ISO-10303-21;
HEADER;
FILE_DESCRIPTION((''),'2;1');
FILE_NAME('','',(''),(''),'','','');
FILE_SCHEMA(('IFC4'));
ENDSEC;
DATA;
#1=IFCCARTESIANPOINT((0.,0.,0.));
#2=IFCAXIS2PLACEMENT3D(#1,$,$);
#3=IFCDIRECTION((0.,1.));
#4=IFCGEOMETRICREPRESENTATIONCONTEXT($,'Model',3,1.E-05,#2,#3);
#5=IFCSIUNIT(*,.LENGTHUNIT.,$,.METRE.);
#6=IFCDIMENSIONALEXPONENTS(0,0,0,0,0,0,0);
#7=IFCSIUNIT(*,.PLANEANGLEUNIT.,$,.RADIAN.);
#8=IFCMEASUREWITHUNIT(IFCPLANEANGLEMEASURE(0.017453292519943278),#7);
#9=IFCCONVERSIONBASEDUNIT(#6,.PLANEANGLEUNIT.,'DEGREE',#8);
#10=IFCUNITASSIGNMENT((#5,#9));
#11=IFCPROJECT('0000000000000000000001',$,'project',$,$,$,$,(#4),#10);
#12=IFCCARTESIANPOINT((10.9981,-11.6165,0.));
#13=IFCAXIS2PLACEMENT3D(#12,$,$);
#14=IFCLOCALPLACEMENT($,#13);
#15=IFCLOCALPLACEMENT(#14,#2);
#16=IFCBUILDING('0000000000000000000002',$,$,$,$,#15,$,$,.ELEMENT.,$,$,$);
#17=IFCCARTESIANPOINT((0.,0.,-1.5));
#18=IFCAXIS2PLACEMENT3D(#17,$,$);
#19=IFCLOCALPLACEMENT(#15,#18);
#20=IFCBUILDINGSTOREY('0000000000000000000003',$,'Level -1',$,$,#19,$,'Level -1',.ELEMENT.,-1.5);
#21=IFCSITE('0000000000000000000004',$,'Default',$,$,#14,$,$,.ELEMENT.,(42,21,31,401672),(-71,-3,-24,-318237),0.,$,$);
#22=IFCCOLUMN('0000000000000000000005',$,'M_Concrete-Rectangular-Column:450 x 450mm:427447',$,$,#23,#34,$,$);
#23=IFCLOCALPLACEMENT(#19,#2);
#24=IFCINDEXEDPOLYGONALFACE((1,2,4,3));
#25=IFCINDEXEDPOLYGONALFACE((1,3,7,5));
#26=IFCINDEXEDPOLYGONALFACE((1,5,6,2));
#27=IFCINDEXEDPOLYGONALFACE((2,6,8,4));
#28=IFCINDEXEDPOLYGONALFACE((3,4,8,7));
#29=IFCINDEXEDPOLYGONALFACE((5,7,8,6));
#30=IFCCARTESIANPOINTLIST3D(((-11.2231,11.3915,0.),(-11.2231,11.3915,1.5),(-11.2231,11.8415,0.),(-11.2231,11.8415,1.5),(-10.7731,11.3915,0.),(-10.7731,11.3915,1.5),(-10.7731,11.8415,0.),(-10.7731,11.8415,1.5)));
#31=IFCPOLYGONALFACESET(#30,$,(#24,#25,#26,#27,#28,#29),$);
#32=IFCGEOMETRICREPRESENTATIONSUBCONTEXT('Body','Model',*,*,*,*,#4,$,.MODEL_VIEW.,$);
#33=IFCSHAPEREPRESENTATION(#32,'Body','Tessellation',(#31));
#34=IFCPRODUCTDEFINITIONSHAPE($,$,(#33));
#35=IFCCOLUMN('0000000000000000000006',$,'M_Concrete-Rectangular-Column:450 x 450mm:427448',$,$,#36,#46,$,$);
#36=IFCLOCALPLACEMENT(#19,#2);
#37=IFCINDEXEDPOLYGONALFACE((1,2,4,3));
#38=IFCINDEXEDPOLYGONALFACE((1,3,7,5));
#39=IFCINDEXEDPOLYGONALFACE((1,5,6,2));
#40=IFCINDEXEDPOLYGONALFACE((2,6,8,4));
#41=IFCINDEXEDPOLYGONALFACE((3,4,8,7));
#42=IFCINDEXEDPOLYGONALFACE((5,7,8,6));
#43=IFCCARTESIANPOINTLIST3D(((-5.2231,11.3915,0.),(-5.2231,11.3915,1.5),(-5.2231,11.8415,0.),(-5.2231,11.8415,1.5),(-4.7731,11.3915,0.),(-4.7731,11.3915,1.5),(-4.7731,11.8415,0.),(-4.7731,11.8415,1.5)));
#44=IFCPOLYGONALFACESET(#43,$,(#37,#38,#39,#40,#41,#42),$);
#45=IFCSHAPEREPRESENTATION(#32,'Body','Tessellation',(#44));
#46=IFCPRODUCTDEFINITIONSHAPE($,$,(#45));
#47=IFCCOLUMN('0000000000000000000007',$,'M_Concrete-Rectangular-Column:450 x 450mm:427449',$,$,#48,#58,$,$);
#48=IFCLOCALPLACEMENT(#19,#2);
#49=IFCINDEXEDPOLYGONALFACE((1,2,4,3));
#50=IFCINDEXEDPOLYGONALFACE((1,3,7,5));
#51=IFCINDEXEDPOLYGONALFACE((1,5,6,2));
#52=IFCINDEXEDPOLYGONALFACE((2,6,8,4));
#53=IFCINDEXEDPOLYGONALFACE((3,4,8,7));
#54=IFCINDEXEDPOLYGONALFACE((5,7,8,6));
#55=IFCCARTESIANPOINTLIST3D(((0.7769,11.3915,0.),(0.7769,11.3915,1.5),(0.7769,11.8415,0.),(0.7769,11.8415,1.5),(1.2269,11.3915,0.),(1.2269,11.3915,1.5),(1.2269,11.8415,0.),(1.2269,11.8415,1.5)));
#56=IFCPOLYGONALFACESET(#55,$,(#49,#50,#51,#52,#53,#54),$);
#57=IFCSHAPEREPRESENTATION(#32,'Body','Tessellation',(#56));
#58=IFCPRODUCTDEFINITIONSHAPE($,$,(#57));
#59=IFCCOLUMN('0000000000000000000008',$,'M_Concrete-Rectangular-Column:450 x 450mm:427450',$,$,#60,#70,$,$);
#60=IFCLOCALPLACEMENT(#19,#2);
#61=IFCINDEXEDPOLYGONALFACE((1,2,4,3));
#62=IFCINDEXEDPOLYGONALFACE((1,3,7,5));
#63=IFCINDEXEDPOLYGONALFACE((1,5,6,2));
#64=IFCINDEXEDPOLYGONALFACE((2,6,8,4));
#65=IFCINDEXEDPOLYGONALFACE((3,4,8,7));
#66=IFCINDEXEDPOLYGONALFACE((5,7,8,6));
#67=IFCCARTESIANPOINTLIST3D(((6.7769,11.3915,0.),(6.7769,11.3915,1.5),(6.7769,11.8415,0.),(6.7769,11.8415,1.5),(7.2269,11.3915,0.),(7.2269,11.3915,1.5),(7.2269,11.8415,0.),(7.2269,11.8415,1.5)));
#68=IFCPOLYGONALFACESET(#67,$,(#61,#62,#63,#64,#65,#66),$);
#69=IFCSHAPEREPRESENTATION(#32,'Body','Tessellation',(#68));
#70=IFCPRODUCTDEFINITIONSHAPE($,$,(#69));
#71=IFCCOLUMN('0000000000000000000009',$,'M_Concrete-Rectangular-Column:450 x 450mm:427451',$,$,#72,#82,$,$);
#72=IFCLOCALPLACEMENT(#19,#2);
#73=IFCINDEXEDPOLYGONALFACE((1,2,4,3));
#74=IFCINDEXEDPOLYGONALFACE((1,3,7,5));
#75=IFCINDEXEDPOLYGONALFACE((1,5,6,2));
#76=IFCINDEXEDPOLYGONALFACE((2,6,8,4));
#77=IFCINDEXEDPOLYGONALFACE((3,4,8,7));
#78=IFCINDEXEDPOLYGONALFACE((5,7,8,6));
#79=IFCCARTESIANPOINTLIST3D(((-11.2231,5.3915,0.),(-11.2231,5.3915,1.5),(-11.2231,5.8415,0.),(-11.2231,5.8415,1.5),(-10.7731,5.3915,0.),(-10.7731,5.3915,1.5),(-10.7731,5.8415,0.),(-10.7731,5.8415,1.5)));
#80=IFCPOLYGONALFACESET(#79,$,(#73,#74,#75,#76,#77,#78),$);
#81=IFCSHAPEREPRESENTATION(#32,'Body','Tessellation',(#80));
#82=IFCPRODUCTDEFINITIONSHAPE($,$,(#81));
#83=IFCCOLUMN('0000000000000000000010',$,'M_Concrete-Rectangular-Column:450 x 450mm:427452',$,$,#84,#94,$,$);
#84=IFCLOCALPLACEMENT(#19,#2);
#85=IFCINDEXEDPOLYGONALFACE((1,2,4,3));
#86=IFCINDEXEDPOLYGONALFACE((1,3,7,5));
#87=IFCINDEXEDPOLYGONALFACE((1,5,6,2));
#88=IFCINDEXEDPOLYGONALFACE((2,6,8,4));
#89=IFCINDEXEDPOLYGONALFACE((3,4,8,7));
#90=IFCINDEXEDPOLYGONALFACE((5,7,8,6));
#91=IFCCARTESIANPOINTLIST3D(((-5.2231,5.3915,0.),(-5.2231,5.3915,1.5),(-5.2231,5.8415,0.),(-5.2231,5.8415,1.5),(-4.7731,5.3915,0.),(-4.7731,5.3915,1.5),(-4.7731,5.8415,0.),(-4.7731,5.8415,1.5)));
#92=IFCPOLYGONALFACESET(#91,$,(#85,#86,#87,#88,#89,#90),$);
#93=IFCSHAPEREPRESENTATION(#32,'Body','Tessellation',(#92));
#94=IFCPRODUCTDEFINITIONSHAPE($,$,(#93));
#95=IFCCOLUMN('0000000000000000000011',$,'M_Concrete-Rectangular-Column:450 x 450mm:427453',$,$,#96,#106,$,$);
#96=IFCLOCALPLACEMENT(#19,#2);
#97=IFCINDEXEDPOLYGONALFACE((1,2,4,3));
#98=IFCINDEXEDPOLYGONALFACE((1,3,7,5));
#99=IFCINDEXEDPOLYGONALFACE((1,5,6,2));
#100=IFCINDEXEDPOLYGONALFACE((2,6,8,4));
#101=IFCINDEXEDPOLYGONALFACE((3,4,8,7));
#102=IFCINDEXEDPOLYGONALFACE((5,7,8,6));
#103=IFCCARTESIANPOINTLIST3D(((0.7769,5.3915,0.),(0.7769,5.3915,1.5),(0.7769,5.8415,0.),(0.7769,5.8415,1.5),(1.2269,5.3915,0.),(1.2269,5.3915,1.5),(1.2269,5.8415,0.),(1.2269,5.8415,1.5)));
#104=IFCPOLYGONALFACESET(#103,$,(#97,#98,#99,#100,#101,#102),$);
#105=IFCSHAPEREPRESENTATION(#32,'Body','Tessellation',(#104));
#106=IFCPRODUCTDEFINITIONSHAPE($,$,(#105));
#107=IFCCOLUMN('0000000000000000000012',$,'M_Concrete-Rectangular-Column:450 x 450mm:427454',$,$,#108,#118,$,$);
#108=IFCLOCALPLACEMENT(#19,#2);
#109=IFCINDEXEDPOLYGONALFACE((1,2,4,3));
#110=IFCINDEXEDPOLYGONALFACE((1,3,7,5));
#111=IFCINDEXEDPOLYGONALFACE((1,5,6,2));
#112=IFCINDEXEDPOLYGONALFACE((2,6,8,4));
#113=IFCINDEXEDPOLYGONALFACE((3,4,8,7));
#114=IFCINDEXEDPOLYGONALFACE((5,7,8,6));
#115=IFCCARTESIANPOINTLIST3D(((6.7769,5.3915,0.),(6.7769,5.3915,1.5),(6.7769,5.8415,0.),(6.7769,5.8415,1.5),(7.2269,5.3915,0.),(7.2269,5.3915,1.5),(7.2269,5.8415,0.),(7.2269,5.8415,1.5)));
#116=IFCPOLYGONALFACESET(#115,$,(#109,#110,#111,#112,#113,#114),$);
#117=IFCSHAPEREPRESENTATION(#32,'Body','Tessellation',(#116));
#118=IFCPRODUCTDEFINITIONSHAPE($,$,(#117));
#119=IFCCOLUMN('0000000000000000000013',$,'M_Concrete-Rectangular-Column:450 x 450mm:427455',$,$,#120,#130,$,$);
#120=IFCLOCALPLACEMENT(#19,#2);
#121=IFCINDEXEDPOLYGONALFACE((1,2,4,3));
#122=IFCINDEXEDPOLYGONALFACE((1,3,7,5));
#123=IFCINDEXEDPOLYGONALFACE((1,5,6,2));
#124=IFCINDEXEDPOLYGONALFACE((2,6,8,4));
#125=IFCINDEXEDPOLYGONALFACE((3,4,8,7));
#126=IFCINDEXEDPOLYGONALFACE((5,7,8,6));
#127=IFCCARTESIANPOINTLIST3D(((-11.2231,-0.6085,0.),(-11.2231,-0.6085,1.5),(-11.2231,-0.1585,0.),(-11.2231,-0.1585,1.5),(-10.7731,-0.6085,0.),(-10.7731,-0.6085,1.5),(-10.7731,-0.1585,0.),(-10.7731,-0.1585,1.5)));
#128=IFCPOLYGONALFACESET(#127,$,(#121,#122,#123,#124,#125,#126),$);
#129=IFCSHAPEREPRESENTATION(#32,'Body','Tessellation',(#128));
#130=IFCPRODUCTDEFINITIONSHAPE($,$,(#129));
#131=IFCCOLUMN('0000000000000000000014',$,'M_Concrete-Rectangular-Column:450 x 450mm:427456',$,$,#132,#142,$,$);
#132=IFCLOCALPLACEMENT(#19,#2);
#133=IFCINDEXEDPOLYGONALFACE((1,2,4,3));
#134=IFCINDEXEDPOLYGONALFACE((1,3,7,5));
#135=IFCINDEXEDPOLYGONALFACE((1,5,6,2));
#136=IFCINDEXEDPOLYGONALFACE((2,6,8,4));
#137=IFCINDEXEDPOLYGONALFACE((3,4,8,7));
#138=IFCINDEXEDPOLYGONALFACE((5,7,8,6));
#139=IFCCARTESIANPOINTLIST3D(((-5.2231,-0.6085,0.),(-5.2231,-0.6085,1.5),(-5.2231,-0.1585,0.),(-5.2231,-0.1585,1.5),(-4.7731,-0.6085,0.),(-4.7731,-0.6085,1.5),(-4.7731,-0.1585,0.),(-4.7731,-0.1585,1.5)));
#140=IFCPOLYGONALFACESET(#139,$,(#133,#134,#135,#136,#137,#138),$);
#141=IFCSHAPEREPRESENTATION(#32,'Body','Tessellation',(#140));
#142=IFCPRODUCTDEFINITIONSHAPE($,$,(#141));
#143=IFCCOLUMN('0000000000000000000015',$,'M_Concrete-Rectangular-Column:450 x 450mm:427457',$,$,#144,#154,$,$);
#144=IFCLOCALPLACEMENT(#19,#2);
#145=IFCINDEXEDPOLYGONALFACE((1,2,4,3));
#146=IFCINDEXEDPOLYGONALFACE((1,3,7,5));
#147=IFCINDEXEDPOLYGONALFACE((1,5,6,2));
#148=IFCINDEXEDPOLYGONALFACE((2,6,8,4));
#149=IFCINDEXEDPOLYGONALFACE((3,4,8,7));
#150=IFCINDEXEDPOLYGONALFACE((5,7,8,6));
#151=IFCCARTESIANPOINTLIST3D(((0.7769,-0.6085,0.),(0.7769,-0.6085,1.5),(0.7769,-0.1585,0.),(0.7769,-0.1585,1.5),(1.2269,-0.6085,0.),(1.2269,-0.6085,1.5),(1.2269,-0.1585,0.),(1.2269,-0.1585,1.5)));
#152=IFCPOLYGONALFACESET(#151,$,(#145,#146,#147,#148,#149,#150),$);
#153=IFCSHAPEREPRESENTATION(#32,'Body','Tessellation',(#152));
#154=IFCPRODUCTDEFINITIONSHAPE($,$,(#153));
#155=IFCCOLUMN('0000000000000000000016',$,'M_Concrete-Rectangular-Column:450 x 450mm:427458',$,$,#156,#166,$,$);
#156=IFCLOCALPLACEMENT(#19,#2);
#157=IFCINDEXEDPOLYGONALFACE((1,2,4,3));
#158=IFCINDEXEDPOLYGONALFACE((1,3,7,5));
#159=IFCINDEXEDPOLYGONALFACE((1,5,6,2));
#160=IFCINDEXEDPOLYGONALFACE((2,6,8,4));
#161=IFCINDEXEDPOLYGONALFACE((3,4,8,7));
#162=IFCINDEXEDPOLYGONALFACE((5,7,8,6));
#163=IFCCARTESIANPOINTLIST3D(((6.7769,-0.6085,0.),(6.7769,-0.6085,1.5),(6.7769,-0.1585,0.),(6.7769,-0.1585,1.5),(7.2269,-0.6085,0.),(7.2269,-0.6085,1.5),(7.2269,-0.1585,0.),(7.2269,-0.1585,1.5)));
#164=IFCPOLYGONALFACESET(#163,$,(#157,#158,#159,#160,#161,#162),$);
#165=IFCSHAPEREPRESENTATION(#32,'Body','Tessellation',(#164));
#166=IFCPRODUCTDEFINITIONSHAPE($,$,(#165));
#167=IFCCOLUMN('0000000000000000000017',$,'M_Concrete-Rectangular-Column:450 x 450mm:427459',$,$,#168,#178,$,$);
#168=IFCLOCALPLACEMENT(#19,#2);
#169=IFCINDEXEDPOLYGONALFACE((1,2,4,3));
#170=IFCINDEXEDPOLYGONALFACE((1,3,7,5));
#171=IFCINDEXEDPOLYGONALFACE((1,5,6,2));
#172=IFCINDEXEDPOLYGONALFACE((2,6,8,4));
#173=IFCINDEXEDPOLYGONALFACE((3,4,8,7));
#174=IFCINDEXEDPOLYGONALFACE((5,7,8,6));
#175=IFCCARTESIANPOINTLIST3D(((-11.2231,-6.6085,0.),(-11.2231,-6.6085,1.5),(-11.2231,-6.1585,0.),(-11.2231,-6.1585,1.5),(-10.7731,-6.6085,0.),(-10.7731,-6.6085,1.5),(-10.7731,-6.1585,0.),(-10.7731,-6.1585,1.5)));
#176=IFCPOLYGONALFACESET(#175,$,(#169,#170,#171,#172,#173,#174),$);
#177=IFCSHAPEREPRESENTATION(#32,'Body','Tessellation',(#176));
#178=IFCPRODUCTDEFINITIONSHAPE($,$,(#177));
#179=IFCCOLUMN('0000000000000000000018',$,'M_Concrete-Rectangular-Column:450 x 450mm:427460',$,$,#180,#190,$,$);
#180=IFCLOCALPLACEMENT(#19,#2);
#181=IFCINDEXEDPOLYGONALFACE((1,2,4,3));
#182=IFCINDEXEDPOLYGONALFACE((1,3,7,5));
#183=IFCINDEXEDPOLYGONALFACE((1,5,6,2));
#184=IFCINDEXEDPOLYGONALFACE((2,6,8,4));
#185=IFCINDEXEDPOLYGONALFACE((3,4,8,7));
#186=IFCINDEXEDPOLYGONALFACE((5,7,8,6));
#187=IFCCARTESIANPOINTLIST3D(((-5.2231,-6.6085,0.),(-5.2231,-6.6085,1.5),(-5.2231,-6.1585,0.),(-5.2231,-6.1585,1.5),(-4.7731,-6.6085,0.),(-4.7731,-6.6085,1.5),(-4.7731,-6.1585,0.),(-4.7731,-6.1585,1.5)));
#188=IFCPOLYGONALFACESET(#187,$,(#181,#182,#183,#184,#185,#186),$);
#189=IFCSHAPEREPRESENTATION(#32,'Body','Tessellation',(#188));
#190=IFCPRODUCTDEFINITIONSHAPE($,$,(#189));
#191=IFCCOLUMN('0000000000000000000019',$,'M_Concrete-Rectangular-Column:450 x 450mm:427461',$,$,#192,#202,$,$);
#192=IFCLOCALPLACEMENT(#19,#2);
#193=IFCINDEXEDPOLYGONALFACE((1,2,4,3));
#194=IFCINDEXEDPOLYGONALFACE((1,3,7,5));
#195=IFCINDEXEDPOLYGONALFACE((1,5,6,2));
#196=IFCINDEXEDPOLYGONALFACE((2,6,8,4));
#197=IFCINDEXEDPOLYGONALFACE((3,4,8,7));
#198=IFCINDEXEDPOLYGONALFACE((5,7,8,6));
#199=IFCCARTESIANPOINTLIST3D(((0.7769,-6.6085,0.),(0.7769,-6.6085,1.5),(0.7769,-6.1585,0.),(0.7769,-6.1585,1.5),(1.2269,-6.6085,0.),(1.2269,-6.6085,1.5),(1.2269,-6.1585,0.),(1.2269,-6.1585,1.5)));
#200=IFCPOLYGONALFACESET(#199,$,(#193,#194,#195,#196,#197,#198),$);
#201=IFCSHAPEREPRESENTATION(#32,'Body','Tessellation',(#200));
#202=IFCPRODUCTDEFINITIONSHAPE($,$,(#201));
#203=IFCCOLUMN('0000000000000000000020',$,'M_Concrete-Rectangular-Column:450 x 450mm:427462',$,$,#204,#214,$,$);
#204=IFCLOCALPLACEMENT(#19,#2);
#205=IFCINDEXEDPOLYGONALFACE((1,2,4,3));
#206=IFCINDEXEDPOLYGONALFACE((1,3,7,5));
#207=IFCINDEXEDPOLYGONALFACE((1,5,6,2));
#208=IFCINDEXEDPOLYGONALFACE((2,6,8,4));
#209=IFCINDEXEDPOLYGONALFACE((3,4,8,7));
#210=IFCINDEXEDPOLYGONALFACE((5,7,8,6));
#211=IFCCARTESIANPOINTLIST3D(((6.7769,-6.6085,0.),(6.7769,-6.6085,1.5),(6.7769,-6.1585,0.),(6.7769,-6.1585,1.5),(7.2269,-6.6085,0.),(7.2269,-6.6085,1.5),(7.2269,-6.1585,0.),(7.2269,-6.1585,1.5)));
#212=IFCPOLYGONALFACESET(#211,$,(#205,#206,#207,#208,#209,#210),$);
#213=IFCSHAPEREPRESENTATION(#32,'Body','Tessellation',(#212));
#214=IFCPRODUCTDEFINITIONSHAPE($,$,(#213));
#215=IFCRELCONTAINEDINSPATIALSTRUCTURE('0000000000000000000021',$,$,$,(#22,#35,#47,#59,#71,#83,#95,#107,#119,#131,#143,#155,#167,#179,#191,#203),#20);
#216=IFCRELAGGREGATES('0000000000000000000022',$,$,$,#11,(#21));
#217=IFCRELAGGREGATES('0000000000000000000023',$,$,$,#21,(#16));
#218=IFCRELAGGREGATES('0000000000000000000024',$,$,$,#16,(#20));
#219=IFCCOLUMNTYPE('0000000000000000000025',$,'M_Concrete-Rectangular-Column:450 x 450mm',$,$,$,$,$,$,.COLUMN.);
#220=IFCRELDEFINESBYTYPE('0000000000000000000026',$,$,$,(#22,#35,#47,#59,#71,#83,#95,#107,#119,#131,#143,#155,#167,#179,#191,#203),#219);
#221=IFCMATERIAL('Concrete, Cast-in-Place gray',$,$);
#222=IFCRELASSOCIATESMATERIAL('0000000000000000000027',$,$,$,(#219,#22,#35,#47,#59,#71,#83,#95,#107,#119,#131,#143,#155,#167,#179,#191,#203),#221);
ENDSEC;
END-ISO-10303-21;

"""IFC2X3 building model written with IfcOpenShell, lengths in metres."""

from ifc_helpers import new_model, entity, si_unit, converted_unit, direction, frame, origin, origin_2d_with_axis, place, context, subcontext, project, spatial, rectangle, extrude, source, transform, mapped, material, type_object, type_shapes, element, save


model = new_model("IFC2X3")

# Units and contexts
model_context = context("Model", 3, precision=1e-05, world=origin(), true_north=direction((0.0, 1.0)))
body_context = subcontext(model_context, "Body", "Model", "MODEL_VIEW")
ifc_project = project(units=[si_unit("LENGTHUNIT", "METRE"), converted_unit("PLANEANGLEUNIT", "DEGREE", entity("IfcPlaneAngleMeasure", 0.017453292519943278), si_unit("PLANEANGLEUNIT", "RADIAN"), dimensions=[0, 0, 0, 0, 0, 0, 0])], contexts=[model_context])

# Site, building, storey
site_placement = place(None, frame((10.9981, -11.6165, 0.0)))
site = spatial("IfcSite", under=ifc_project, at=site_placement, Name="Default", CompositionType="ELEMENT", RefLatitude=(42, 21, 31, 401672), RefLongitude=(-71, -3, -24, -318237), RefElevation=0.0)
building_placement = place(site_placement, origin())
building = spatial("IfcBuilding", under=site, at=building_placement, CompositionType="ELEMENT")
storey_placement = place(building_placement, frame((0.0, 0.0, -1.5)))
storey = spatial("IfcBuildingStorey", under=building, at=storey_placement, Name="Level -1", LongName="Level -1", CompositionType="ELEMENT", Elevation=-1.5)

# Columns
ifc_material = material(Name="Concrete, Cast-in-Place gray")
column_type = type_object("IfcColumnType", Name="M_Concrete-Rectangular-Column:450 x 450mm", PredefinedType="COLUMN", material=ifc_material)
shared_shape = source(origin(), body_context, "Body", "SweptSolid", [
    extrude(rectangle(XDim=0.45, YDim=0.45, at=origin_2d_with_axis()), frame((0.0, 0.0, -1.5), z_axis=(0.0, 0.0, 1.0), x_axis=(-1.0, 0.0, 0.0)), (0.0, 0.0, 1.0), 1.5),
])
type_shapes(column_type, [shared_shape])
for number, where, name in (
    (1, (-10.9981, 11.6165, 1.5), "M_Concrete-Rectangular-Column:450 x 450mm:427447"),
    (2, (-4.9981, 11.6165, 1.5), "M_Concrete-Rectangular-Column:450 x 450mm:427448"),
    (3, (1.0019, 11.6165, 1.5), "M_Concrete-Rectangular-Column:450 x 450mm:427449"),
    (4, (7.0019, 11.6165, 1.5), "M_Concrete-Rectangular-Column:450 x 450mm:427450"),
    (5, (-10.9981, 5.6165, 1.5), "M_Concrete-Rectangular-Column:450 x 450mm:427451"),
    (6, (-4.9981, 5.6165, 1.5), "M_Concrete-Rectangular-Column:450 x 450mm:427452"),
    (7, (1.0019, 5.6165, 1.5), "M_Concrete-Rectangular-Column:450 x 450mm:427453"),
    (8, (7.0019, 5.6165, 1.5), "M_Concrete-Rectangular-Column:450 x 450mm:427454"),
    (9, (-10.9981, -0.3835, 1.5), "M_Concrete-Rectangular-Column:450 x 450mm:427455"),
    (10, (-4.9981, -0.3835, 1.5), "M_Concrete-Rectangular-Column:450 x 450mm:427456"),
    (11, (1.0019, -0.3835, 1.5), "M_Concrete-Rectangular-Column:450 x 450mm:427457"),
    (12, (7.0019, -0.3835, 1.5), "M_Concrete-Rectangular-Column:450 x 450mm:427458"),
    (13, (-10.9981, -6.3835, 1.5), "M_Concrete-Rectangular-Column:450 x 450mm:427459"),
    (14, (-4.9981, -6.3835, 1.5), "M_Concrete-Rectangular-Column:450 x 450mm:427460"),
    (15, (1.0019, -6.3835, 1.5), "M_Concrete-Rectangular-Column:450 x 450mm:427461"),
    (16, (7.0019, -6.3835, 1.5), "M_Concrete-Rectangular-Column:450 x 450mm:427462"),
):
    element("IfcColumn", number, at=place(storey_placement, frame(where)), inside=storey, type_object=column_type, material=ifc_material, Name=name, context=body_context, shape_type="MappedRepresentation", body=[
        mapped(shared_shape, transform((0.0, 0.0, 0.0), scale=1.0)),
    ])

save(model, "model.ifc")
